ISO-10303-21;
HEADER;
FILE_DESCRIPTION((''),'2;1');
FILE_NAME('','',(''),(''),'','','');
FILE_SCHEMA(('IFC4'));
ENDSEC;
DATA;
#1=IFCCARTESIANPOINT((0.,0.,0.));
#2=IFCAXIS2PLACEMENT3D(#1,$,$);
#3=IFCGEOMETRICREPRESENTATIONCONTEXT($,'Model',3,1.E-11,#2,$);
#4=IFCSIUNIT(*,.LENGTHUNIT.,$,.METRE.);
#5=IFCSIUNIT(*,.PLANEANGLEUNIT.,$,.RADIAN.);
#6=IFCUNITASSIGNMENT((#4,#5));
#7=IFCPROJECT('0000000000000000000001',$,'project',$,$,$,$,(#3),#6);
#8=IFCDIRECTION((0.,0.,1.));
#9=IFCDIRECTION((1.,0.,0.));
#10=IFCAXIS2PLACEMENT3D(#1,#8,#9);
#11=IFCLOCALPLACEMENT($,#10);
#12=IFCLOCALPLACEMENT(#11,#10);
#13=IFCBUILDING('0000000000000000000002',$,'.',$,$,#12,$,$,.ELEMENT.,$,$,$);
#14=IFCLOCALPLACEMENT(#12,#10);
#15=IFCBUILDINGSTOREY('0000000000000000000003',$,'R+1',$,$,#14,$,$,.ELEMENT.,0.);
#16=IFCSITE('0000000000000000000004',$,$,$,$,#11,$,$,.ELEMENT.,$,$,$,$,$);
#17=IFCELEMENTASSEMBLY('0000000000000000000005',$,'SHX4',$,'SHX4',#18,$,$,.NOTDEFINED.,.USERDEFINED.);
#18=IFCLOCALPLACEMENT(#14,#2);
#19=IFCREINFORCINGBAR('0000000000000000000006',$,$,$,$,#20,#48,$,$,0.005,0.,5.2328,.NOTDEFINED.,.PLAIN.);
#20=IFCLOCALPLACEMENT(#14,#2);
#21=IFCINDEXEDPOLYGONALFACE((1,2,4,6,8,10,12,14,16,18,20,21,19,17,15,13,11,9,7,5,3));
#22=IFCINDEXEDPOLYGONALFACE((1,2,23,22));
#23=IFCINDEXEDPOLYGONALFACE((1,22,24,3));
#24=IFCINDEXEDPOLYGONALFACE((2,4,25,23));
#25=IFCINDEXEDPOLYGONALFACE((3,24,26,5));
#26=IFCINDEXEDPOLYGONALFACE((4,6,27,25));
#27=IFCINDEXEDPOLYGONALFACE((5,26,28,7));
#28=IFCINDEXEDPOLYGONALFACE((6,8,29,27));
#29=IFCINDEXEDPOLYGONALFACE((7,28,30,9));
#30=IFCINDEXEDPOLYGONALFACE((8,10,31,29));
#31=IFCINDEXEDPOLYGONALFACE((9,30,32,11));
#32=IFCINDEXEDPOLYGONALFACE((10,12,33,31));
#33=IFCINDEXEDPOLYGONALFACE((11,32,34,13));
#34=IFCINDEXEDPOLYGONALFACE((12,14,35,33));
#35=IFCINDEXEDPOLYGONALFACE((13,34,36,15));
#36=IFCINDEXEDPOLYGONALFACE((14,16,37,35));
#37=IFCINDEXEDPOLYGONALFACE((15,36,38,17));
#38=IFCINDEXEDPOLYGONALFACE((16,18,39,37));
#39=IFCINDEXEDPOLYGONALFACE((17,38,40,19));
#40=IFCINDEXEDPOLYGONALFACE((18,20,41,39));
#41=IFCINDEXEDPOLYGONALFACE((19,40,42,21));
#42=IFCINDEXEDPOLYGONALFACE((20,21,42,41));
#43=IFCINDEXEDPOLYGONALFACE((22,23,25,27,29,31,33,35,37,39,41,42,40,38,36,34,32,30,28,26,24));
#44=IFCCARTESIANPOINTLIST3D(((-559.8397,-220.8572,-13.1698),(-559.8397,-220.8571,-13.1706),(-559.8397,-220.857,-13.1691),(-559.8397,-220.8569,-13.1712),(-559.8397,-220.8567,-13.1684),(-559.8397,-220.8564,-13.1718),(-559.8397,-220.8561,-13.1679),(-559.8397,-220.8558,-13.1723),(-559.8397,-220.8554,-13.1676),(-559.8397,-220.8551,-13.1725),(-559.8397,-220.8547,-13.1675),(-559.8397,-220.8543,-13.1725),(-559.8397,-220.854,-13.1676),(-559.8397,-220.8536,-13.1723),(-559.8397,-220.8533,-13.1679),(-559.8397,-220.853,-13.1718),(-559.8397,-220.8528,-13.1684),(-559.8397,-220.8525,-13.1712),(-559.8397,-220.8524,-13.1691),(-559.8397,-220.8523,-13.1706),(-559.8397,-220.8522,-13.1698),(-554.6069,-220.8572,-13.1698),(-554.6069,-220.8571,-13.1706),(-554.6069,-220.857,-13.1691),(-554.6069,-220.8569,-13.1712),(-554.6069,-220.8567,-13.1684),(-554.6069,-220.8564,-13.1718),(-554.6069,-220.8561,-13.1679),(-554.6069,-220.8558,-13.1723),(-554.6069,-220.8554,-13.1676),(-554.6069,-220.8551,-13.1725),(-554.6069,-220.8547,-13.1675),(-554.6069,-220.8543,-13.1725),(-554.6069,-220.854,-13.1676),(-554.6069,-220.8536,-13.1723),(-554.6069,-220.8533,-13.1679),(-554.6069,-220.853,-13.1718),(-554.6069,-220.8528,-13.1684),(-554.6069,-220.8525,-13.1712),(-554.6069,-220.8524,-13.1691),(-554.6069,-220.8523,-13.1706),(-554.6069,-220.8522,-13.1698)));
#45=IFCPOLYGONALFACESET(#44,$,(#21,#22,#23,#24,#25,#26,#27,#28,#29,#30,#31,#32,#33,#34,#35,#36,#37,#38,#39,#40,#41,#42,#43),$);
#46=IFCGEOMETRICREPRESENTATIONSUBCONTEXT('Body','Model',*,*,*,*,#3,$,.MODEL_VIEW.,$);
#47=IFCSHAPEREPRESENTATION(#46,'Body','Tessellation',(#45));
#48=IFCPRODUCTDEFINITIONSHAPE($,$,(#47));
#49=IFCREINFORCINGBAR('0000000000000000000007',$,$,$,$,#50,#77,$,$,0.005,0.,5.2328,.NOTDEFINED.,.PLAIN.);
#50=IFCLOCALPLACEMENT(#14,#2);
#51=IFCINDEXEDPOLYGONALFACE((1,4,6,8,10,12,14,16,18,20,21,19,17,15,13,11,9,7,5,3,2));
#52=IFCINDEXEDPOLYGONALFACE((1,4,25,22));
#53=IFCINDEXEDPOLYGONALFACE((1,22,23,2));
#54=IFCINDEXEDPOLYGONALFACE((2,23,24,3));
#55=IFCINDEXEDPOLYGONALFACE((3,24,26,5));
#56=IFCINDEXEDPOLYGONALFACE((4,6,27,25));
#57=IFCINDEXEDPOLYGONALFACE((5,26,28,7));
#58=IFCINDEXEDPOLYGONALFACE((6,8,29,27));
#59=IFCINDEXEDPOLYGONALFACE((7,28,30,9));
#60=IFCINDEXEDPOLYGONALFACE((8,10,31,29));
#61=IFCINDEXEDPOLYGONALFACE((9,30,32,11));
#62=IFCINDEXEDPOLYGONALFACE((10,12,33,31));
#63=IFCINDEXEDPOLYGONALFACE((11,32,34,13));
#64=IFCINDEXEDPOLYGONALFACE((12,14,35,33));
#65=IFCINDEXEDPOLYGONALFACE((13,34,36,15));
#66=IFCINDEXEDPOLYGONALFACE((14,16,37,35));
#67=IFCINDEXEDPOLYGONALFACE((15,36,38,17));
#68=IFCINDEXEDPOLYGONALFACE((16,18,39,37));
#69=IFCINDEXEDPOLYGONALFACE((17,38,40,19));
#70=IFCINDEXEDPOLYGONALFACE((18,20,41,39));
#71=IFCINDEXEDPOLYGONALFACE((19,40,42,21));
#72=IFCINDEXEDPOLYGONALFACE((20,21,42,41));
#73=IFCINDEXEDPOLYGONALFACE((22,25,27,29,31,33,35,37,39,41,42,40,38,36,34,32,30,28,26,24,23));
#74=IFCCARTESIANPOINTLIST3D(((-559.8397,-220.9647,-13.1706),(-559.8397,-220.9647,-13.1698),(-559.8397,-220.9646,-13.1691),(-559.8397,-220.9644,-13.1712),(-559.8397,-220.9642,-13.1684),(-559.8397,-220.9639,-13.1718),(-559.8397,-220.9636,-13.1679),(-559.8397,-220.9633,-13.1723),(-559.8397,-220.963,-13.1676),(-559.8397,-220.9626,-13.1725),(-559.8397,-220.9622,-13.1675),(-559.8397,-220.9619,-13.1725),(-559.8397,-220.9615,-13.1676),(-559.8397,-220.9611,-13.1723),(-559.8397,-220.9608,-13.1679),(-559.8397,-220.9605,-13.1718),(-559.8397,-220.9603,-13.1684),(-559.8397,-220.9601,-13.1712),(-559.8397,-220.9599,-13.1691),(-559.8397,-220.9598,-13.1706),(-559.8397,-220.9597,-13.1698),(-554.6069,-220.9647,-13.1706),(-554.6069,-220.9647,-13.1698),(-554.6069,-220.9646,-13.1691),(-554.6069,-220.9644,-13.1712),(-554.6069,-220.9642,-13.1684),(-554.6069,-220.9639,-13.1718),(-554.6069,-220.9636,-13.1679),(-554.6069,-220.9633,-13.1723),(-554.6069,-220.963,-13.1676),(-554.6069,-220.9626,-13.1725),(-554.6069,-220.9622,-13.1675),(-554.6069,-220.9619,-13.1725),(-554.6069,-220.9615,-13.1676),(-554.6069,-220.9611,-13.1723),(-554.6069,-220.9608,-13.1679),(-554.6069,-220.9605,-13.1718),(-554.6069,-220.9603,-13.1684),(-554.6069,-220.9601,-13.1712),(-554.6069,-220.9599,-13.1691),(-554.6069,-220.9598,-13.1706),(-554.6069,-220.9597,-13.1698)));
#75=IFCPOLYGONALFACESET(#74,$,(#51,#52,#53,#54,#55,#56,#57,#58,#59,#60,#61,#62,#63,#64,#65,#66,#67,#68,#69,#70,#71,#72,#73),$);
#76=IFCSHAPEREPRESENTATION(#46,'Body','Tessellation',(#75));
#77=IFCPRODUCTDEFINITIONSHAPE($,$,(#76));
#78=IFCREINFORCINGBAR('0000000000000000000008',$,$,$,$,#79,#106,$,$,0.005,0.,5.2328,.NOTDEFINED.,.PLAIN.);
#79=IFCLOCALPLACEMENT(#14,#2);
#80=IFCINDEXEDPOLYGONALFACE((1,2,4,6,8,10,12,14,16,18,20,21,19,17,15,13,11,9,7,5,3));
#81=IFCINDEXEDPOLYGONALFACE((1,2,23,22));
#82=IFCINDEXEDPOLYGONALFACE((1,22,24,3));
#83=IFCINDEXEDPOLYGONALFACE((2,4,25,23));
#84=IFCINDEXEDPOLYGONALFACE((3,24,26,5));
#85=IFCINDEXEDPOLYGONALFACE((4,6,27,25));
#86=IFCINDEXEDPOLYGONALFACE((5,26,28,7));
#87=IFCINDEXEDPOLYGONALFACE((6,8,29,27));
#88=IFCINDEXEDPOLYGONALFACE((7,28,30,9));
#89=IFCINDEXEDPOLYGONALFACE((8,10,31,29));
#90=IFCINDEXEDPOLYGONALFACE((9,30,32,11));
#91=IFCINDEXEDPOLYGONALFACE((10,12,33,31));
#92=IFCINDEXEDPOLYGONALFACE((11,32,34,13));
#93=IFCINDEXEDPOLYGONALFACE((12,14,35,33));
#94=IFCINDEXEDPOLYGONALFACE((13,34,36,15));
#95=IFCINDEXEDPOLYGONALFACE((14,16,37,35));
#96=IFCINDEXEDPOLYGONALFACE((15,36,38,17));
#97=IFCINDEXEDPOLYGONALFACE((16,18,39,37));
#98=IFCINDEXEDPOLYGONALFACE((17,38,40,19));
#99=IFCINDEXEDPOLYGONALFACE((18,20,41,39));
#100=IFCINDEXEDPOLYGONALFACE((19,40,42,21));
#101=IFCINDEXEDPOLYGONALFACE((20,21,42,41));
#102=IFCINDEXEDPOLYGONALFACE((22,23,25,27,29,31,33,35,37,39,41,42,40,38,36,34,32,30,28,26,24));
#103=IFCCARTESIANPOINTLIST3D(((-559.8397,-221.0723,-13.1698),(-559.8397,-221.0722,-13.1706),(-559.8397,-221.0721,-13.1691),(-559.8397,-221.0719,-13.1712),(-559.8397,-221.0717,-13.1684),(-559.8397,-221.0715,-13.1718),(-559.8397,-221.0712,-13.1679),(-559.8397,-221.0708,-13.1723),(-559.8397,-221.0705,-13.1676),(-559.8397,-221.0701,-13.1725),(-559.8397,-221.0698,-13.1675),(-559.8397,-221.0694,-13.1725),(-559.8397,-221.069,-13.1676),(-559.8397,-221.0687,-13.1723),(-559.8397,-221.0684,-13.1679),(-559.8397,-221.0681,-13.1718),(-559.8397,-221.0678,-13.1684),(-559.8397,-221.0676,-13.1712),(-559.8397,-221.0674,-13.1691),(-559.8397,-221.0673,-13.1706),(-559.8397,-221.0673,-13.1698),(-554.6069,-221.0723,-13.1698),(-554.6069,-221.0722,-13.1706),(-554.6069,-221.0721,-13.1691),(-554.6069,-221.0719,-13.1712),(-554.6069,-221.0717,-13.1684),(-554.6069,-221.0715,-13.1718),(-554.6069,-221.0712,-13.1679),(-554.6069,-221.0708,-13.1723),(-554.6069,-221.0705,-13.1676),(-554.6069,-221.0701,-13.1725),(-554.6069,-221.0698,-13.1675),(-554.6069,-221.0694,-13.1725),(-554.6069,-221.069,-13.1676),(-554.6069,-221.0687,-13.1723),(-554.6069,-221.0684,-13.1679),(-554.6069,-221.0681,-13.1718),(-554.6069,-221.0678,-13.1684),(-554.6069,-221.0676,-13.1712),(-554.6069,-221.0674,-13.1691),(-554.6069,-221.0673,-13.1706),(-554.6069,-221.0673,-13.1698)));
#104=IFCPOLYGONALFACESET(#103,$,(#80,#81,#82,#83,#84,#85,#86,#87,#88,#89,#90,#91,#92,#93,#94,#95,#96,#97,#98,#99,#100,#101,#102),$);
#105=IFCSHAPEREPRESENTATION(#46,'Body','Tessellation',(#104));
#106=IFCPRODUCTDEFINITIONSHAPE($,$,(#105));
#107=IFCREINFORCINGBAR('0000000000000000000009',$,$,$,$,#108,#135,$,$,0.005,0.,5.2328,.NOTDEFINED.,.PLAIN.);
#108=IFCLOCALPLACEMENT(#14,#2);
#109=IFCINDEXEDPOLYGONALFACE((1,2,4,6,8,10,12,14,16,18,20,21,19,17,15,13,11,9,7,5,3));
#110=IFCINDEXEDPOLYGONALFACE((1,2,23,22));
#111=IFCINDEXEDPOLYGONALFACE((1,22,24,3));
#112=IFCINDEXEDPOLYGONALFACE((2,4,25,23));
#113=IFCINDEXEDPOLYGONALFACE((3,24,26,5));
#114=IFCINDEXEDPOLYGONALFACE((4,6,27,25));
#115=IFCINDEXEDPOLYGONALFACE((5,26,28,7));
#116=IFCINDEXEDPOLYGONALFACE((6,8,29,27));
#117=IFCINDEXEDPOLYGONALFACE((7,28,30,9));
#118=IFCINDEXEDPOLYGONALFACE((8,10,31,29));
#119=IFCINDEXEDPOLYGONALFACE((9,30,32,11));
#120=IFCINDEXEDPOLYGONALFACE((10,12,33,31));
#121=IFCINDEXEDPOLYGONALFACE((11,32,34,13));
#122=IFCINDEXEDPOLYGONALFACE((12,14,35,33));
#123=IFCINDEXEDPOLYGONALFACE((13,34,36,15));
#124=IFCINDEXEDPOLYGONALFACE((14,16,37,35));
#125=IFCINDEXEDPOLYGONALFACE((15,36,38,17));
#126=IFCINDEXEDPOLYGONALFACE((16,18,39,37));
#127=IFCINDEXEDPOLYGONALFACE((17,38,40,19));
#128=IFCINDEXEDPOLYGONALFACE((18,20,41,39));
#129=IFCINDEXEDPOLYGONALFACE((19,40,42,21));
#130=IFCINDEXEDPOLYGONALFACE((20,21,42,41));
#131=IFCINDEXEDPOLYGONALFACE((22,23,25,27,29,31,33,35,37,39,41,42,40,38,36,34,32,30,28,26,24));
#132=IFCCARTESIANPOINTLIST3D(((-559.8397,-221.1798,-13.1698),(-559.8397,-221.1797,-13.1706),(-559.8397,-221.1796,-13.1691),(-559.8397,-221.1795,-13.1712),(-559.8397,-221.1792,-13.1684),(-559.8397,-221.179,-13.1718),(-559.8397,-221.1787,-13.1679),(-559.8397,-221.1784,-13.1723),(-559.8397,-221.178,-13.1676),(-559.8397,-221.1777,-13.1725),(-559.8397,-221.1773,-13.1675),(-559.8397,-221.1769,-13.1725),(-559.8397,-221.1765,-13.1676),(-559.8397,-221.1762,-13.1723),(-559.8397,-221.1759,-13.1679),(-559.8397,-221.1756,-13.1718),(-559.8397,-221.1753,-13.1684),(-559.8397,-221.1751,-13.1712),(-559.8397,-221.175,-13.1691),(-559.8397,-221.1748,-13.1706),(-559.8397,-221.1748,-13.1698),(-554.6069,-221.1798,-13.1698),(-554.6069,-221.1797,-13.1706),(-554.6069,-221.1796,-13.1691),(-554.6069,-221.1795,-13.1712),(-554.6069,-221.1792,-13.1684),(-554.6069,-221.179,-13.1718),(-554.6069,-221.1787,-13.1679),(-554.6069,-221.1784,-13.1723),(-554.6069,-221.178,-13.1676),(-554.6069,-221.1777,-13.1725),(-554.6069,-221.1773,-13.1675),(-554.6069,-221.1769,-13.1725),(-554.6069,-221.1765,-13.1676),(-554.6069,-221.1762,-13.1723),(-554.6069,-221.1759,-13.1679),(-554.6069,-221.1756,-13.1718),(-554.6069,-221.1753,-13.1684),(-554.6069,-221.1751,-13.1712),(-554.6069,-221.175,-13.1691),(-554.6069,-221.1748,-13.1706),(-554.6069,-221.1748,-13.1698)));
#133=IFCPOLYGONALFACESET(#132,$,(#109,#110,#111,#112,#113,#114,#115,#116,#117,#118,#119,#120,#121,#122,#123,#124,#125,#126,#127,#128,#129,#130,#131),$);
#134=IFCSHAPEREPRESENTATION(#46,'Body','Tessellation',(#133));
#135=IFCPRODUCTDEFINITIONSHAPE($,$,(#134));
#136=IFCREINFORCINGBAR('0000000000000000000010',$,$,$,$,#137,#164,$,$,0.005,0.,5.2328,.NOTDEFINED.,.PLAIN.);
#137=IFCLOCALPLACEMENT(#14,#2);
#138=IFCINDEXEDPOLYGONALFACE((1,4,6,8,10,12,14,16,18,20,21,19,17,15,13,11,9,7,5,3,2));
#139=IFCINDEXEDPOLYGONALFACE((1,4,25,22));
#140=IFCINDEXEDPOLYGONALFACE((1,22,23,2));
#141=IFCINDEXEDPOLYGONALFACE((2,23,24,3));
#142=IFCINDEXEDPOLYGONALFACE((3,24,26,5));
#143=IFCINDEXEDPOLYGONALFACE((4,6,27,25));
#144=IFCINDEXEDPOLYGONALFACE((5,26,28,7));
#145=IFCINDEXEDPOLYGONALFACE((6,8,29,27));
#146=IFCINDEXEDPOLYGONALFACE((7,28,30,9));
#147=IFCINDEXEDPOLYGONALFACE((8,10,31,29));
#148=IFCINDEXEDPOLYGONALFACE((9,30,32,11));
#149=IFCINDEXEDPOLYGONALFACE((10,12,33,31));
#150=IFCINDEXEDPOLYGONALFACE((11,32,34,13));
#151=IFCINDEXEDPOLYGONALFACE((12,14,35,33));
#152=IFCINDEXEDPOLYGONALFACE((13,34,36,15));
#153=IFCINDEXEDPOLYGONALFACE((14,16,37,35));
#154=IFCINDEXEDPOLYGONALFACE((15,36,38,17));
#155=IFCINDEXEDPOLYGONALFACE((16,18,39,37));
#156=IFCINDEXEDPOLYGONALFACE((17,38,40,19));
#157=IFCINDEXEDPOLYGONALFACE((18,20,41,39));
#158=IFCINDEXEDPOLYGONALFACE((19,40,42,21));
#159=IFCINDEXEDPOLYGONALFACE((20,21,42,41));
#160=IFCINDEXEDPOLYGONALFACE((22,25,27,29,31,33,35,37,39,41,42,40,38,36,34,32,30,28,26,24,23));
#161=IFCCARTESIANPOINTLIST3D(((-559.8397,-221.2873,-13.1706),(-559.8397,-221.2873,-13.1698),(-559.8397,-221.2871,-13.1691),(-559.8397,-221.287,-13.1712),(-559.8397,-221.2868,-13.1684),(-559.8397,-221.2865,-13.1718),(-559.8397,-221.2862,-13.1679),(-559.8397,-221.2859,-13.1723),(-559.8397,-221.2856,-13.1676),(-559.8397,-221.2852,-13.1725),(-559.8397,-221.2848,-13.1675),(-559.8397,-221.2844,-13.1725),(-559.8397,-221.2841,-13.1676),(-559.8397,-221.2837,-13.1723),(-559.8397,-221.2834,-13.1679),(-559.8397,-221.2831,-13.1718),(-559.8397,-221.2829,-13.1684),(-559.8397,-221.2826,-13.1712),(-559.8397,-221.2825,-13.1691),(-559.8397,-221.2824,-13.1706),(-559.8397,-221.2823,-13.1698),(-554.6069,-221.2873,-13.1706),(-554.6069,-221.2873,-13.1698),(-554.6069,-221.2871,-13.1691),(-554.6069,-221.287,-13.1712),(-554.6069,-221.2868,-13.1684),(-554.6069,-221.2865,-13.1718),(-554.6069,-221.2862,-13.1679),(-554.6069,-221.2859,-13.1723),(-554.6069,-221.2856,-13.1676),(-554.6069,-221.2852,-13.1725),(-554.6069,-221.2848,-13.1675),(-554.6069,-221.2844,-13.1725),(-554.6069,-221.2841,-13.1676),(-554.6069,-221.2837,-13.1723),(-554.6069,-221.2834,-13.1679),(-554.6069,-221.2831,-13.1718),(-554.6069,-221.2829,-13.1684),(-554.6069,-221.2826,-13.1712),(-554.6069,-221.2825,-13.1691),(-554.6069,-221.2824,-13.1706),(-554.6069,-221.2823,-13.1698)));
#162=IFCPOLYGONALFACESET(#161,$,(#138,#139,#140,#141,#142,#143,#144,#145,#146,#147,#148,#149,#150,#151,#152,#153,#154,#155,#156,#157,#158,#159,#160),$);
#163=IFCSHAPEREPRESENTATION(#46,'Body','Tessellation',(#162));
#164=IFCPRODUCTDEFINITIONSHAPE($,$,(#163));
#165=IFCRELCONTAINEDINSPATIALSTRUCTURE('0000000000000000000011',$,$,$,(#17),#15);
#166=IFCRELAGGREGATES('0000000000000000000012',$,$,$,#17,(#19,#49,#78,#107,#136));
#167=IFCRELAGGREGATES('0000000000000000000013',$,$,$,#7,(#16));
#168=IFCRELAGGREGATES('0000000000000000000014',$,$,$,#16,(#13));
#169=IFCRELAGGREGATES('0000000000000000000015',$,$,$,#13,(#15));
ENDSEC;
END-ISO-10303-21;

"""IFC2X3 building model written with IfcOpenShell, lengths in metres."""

from ifc_helpers import new_model, entity, si_unit, origin, origin_with_axes, place, context, subcontext, project, spatial, shape, element, aggregate, save


model = new_model("IFC2X3")

# Units and contexts
model_context = context("Model", 3, precision=1e-11, world=origin())
body_context = subcontext(model_context, "Body", "Model", "MODEL_VIEW")
ifc_project = project(units=[si_unit("LENGTHUNIT", "METRE"), si_unit("PLANEANGLEUNIT", "RADIAN")], contexts=[model_context])

# Site, building, storey
site_placement = place(None, origin_with_axes())
site = spatial("IfcSite", under=ifc_project, at=site_placement, CompositionType="ELEMENT")
building_placement = place(site_placement, origin_with_axes())
building = spatial("IfcBuilding", under=site, at=building_placement, Name=".", CompositionType="ELEMENT")
storey_placement = place(building_placement, origin_with_axes())
storey = spatial("IfcBuildingStorey", under=building, at=storey_placement, Name="R+1", CompositionType="ELEMENT", Elevation=0.0)

# Element assembly, reinforcing bars
assembly_1_placement = place(storey_placement, origin_with_axes())
assembly_1 = element("IfcElementAssembly", 1, at=assembly_1_placement, inside=storey, Name="SHX4", ObjectType="SHX4", AssemblyPlace="NOTDEFINED", PredefinedType="USERDEFINED")
reinforcing_bar_1_placement = place(assembly_1_placement, origin_with_axes())
reinforcing_bar_1 = element("IfcReinforcingBar", 2, at=reinforcing_bar_1_placement, BarLength=5.2328, BarRole="NOTDEFINED", BarSurface="PLAIN", CrossSectionArea=0.0, NominalDiameter=0.005, shapes=[
    shape(body_context, "Body", "AdvancedSweptSolid", [entity("IfcSweptDiskSolid", entity("IfcPolyline", [entity("IfcCartesianPoint", [554.6069, 220.8547, 13.17]), entity("IfcCartesianPoint", [559.8397, 220.8547, 13.17])]), 0.0025, None, 0.0, 5.2328)]),
    shape(body_context, "Body", "AdvancedSweptSolid", [entity("IfcSweptDiskSolid", entity("IfcPolyline", [entity("IfcCartesianPoint", [554.6069, 220.8547, 13.17]), entity("IfcCartesianPoint", [559.8397, 220.8547, 13.17])]), 0.0025, None, 0.0, 5.2328)]),
])
reinforcing_bar_2_placement = place(assembly_1_placement, origin_with_axes())
reinforcing_bar_2 = element("IfcReinforcingBar", 3, at=reinforcing_bar_2_placement, BarLength=5.2328, BarRole="NOTDEFINED", BarSurface="PLAIN", CrossSectionArea=0.0, NominalDiameter=0.005, shapes=[
    shape(body_context, "Body", "AdvancedSweptSolid", [entity("IfcSweptDiskSolid", entity("IfcPolyline", [entity("IfcCartesianPoint", [554.6069, 220.9622, 13.17]), entity("IfcCartesianPoint", [559.8397, 220.9622, 13.17])]), 0.0025, None, 0.0, 5.2328)]),
    shape(body_context, "Body", "AdvancedSweptSolid", [entity("IfcSweptDiskSolid", entity("IfcPolyline", [entity("IfcCartesianPoint", [554.6069, 220.9622, 13.17]), entity("IfcCartesianPoint", [559.8397, 220.9622, 13.17])]), 0.0025, None, 0.0, 5.2328)]),
])
reinforcing_bar_3_placement = place(assembly_1_placement, origin_with_axes())
reinforcing_bar_3 = element("IfcReinforcingBar", 4, at=reinforcing_bar_3_placement, BarLength=5.2328, BarRole="NOTDEFINED", BarSurface="PLAIN", CrossSectionArea=0.0, NominalDiameter=0.005, shapes=[
    shape(body_context, "Body", "AdvancedSweptSolid", [entity("IfcSweptDiskSolid", entity("IfcPolyline", [entity("IfcCartesianPoint", [554.6069, 221.0698, 13.17]), entity("IfcCartesianPoint", [559.8397, 221.0698, 13.17])]), 0.0025, None, 0.0, 5.2328)]),
    shape(body_context, "Body", "AdvancedSweptSolid", [entity("IfcSweptDiskSolid", entity("IfcPolyline", [entity("IfcCartesianPoint", [554.6069, 221.0698, 13.17]), entity("IfcCartesianPoint", [559.8397, 221.0698, 13.17])]), 0.0025, None, 0.0, 5.2328)]),
])
reinforcing_bar_4_placement = place(assembly_1_placement, origin_with_axes())
reinforcing_bar_4 = element("IfcReinforcingBar", 5, at=reinforcing_bar_4_placement, BarLength=5.2328, BarRole="NOTDEFINED", BarSurface="PLAIN", CrossSectionArea=0.0, NominalDiameter=0.005, shapes=[
    shape(body_context, "Body", "AdvancedSweptSolid", [entity("IfcSweptDiskSolid", entity("IfcPolyline", [entity("IfcCartesianPoint", [554.6069, 221.1773, 13.17]), entity("IfcCartesianPoint", [559.8397, 221.1773, 13.17])]), 0.0025, None, 0.0, 5.2328)]),
    shape(body_context, "Body", "AdvancedSweptSolid", [entity("IfcSweptDiskSolid", entity("IfcPolyline", [entity("IfcCartesianPoint", [554.6069, 221.1773, 13.17]), entity("IfcCartesianPoint", [559.8397, 221.1773, 13.17])]), 0.0025, None, 0.0, 5.2328)]),
])
reinforcing_bar_5_placement = place(assembly_1_placement, origin_with_axes())
reinforcing_bar_5 = element("IfcReinforcingBar", 6, at=reinforcing_bar_5_placement, BarLength=5.2328, BarRole="NOTDEFINED", BarSurface="PLAIN", CrossSectionArea=0.0, NominalDiameter=0.005, shapes=[
    shape(body_context, "Body", "AdvancedSweptSolid", [entity("IfcSweptDiskSolid", entity("IfcPolyline", [entity("IfcCartesianPoint", [554.6069, 221.2848, 13.17]), entity("IfcCartesianPoint", [559.8397, 221.2848, 13.17])]), 0.0025, None, 0.0, 5.2328)]),
    shape(body_context, "Body", "AdvancedSweptSolid", [entity("IfcSweptDiskSolid", entity("IfcPolyline", [entity("IfcCartesianPoint", [554.6069, 221.2848, 13.17]), entity("IfcCartesianPoint", [559.8397, 221.2848, 13.17])]), 0.0025, None, 0.0, 5.2328)]),
])
aggregate(assembly_1, [reinforcing_bar_1, reinforcing_bar_2, reinforcing_bar_3, reinforcing_bar_4, reinforcing_bar_5])

save(model, "model.ifc")
